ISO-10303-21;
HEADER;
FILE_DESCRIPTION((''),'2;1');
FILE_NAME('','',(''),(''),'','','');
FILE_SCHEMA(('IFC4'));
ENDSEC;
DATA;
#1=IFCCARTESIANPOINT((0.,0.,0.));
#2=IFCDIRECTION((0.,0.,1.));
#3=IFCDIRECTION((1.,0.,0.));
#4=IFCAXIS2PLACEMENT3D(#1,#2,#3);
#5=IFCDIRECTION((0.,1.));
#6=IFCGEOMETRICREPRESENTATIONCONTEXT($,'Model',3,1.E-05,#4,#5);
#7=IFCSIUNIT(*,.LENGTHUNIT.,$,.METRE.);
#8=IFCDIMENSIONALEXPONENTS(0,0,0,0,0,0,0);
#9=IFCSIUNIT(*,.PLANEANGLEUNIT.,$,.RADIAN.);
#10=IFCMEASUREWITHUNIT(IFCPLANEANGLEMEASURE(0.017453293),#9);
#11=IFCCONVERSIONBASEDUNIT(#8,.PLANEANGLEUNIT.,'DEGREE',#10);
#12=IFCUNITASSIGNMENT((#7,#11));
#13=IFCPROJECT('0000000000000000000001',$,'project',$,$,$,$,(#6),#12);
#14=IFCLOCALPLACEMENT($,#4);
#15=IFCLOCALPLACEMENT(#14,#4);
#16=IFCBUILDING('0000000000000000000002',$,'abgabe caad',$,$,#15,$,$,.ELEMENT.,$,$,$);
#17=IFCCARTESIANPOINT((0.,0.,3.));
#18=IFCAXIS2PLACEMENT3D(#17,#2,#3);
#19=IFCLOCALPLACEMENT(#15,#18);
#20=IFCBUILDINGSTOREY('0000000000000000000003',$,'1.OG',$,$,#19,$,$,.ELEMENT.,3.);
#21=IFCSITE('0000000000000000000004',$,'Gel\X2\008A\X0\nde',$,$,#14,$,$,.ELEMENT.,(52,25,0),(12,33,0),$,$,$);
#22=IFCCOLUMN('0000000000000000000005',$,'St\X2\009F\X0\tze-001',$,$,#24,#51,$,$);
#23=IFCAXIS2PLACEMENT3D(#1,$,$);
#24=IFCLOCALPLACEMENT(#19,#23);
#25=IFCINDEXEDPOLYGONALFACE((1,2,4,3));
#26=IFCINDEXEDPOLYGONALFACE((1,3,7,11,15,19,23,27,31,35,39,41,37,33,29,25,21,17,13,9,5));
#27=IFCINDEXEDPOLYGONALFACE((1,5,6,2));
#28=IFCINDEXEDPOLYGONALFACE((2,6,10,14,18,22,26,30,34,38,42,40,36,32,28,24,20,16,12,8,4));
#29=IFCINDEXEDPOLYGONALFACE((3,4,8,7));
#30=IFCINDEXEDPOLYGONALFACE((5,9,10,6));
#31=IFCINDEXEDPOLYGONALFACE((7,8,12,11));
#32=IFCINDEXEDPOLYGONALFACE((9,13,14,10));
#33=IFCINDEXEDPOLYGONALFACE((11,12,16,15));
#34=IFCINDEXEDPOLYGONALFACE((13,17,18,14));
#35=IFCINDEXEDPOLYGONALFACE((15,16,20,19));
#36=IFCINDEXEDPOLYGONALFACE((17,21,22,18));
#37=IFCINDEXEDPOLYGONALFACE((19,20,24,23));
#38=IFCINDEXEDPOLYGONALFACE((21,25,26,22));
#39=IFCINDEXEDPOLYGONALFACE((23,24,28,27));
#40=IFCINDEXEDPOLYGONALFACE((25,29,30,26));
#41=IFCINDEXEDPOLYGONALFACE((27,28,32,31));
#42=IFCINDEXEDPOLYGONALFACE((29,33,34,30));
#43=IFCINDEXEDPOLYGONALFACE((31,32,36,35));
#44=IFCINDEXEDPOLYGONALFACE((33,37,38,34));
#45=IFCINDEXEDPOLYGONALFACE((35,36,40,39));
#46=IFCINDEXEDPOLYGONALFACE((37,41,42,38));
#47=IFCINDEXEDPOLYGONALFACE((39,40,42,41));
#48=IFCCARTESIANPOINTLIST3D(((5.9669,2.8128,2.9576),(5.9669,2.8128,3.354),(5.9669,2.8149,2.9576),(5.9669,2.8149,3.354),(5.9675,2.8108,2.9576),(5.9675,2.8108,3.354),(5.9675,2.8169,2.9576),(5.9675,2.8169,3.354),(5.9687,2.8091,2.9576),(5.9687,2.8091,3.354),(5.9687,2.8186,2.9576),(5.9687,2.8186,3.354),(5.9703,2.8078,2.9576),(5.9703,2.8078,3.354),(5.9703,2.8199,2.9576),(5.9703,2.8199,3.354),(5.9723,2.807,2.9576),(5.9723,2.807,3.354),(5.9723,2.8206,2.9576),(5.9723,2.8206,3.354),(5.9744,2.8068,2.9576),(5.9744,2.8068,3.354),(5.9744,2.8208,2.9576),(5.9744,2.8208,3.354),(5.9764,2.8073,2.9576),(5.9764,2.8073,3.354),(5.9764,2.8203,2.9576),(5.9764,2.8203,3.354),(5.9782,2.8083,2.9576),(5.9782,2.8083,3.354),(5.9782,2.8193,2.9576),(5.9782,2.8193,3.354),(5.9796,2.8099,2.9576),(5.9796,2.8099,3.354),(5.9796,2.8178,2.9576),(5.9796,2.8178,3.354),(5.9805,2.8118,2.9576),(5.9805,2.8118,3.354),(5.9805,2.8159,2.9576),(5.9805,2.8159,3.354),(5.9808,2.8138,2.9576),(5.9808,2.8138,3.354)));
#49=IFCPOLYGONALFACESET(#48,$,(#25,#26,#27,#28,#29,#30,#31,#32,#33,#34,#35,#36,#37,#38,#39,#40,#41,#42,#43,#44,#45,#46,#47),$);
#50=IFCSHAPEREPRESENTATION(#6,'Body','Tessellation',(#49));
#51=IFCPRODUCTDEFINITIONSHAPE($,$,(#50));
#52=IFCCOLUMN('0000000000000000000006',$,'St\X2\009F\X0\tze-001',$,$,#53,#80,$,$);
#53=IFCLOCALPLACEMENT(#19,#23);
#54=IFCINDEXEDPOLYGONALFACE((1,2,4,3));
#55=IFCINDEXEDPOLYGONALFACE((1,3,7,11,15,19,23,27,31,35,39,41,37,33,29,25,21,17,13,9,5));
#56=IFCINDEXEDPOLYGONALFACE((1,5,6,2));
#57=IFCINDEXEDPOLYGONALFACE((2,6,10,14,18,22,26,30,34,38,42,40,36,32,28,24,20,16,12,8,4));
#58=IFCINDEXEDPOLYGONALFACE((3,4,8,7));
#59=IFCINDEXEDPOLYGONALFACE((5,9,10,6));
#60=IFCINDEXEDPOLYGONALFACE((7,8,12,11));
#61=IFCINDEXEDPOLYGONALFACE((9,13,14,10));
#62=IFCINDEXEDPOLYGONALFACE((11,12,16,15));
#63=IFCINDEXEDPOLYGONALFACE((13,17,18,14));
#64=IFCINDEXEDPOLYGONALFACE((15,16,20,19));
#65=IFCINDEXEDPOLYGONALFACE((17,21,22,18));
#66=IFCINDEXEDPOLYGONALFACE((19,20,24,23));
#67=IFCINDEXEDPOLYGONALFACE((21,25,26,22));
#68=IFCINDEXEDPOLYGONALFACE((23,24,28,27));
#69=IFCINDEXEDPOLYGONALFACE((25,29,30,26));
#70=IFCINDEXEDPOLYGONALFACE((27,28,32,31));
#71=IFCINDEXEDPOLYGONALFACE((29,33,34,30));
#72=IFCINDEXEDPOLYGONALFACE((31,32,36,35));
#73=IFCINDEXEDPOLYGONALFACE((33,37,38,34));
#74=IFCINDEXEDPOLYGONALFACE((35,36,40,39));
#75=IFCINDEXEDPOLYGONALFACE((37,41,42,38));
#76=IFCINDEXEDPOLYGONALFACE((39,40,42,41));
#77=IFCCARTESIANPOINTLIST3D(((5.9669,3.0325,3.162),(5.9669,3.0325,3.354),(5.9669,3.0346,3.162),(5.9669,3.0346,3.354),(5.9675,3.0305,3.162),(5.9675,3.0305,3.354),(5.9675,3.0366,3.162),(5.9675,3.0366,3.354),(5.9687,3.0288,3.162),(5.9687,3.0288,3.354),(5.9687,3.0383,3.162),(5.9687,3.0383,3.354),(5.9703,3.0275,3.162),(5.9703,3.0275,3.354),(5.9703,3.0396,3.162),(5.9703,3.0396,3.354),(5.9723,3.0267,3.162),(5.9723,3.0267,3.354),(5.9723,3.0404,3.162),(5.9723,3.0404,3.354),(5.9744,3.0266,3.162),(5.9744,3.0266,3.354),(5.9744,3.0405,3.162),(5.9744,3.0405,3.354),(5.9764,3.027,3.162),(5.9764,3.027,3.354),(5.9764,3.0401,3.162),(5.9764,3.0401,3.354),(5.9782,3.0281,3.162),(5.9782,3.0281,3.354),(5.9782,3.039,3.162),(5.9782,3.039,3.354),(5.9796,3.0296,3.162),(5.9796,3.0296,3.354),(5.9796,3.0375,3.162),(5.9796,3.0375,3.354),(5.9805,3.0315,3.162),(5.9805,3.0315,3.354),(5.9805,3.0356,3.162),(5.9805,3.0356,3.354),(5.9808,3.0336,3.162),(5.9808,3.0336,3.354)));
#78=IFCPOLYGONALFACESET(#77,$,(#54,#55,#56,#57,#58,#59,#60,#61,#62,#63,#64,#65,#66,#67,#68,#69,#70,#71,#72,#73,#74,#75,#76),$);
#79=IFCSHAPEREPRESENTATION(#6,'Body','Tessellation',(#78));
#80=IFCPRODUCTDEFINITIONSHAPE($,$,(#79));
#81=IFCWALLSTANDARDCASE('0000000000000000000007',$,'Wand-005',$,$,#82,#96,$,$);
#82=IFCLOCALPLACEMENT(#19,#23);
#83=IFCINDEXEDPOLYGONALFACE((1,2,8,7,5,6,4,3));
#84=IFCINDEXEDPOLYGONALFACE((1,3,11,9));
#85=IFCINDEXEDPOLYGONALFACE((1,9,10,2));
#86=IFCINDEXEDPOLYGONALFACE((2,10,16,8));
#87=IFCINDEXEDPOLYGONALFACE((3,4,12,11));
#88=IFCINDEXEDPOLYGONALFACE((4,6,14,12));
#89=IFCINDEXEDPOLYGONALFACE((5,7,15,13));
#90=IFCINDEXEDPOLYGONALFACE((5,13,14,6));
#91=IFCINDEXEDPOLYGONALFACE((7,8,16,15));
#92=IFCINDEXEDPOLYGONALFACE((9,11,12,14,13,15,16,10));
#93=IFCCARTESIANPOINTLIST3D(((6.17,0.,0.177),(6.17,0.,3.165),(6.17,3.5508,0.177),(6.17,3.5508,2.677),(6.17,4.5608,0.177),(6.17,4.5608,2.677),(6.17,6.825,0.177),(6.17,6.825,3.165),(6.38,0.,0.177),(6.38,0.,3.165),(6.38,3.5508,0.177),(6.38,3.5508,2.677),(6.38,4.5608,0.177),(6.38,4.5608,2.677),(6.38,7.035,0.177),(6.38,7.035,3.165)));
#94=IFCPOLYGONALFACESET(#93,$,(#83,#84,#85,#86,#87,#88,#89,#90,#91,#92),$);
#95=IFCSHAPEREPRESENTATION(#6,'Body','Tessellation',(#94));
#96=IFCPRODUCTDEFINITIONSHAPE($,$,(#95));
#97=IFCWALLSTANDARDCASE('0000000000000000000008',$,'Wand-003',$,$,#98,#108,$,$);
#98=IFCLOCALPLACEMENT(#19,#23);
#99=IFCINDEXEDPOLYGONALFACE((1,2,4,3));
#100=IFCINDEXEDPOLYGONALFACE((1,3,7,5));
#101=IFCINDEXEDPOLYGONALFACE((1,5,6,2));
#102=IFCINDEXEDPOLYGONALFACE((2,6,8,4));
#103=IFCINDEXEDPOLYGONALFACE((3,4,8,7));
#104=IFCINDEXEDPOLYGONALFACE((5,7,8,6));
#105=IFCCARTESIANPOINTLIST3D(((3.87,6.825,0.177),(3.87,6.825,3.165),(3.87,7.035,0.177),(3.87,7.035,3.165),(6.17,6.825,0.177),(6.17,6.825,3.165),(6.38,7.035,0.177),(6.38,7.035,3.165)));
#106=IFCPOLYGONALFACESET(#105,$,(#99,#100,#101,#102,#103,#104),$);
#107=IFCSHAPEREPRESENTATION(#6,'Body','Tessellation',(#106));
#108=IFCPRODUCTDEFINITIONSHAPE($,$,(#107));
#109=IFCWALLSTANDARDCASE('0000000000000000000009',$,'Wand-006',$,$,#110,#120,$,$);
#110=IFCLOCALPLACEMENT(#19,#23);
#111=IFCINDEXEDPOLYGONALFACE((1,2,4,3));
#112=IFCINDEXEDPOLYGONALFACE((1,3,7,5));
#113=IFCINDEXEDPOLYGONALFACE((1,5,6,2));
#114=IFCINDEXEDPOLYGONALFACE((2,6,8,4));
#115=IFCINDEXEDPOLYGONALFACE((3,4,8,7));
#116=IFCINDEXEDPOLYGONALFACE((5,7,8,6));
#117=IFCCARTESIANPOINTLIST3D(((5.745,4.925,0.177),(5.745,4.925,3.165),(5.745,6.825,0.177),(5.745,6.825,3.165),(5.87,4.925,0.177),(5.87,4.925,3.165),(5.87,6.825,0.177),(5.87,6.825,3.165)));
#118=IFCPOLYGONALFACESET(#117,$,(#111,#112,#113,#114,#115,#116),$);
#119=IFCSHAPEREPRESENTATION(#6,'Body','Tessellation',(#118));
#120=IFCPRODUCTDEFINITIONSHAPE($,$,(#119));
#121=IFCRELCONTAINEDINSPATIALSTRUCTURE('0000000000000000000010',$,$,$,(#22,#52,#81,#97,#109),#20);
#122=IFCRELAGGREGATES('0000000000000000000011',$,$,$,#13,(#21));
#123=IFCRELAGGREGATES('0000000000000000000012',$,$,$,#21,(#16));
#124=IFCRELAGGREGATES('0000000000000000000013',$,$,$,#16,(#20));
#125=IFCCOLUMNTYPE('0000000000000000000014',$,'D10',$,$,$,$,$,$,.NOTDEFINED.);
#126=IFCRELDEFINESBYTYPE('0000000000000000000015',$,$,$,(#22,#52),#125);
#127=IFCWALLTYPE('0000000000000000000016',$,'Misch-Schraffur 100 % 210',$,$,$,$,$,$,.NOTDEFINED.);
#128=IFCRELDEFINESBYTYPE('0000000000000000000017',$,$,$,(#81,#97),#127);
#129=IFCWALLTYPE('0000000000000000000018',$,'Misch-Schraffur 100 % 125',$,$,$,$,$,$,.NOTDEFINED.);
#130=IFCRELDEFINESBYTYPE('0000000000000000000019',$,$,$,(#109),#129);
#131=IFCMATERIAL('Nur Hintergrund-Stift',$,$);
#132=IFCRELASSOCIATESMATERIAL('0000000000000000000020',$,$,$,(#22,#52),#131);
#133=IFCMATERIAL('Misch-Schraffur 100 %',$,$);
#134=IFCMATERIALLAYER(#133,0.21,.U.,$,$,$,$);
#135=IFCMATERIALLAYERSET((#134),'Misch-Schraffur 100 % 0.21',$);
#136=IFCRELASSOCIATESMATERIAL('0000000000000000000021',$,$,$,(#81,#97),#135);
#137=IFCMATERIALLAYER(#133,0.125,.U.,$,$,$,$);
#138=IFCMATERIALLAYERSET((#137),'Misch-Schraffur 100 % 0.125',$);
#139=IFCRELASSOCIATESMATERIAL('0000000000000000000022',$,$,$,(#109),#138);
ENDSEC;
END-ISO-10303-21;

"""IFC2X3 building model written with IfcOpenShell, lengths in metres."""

from ifc_helpers import new_model, entity, si_unit, converted_unit, direction, frame, origin_with_axes, origin_2d_with_axis, place, context, project, spatial, polyline, rectangle, circle, outline, extrude, material, layer, layer_set, layer_usage, type_object, element, save


model = new_model("IFC2X3")

# Units and contexts
model_context = context("Model", 3, precision=1e-05, world=origin_with_axes(), true_north=direction((0.0, 1.0)))
ifc_project = project(units=[si_unit("LENGTHUNIT", "METRE"), converted_unit("PLANEANGLEUNIT", "DEGREE", entity("IfcPlaneAngleMeasure", 0.017453293), si_unit("PLANEANGLEUNIT", "RADIAN"), dimensions=[0, 0, 0, 0, 0, 0, 0])], contexts=[model_context])

# Site, building, storey
site_placement = place(None, origin_with_axes())
site = spatial("IfcSite", under=ifc_project, at=site_placement, Name="Gel\u008ande", CompositionType="ELEMENT", RefLatitude=(52, 25, 0), RefLongitude=(12, 33, 0))
building_placement = place(site_placement, origin_with_axes())
building = spatial("IfcBuilding", under=site, at=building_placement, Name="abgabe caad", CompositionType="ELEMENT")
storey_placement = place(building_placement, frame((0.0, 0.0, 3.0), z_axis=(0.0, 0.0, 1.0), x_axis=(1.0, 0.0, 0.0)))
storey = spatial("IfcBuildingStorey", under=building, at=storey_placement, Name="1.OG", CompositionType="ELEMENT", Elevation=3.0)

# Columns
ifc_material_1 = material(Name="Nur Hintergrund-Stift")
column_type = type_object("IfcColumnType", Name="D10", PredefinedType="NOTDEFINED")
column_1_placement = place(storey_placement, frame((5.9738, 2.8138, 2.9576), z_axis=(0.0, 0.0, 1.0), x_axis=(1.0, 0.0, 0.0)))
element("IfcColumn", 1, at=column_1_placement, inside=storey, type_object=column_type, material=ifc_material_1, Name="St\u009ftze-001", context=model_context, shape_type="SweptSolid", body=[
    extrude(circle(Radius=0.007, at=origin_2d_with_axis()), origin_with_axes(), (0.0, 0.0, 1.0), 0.3964),
])
column_2_placement = place(storey_placement, frame((5.9738, 3.0336, 3.162), z_axis=(0.0, 0.0, 1.0), x_axis=(1.0, 0.0, 0.0)))
element("IfcColumn", 2, at=column_2_placement, inside=storey, type_object=column_type, material=ifc_material_1, Name="St\u009ftze-001", context=model_context, shape_type="SweptSolid", body=[
    extrude(circle(Radius=0.007, at=origin_2d_with_axis()), origin_with_axes(), (0.0, 0.0, 1.0), 0.192),
])

# Wall, opening
ifc_material_2 = material(Name="Misch-Schraffur 100 %")
ifc_layer_1 = layer(ifc_material_2, 0.21, ventilated="UNKNOWN")
ifc_layer_set_1 = layer_set([ifc_layer_1], Name="Misch-Schraffur 100 % 0.21")
ifc_layer_usage_1 = layer_usage(ifc_layer_set_1, "AXIS2", "NEGATIVE", 0.0)
wall_type_1 = type_object("IfcWallType", Name="Misch-Schraffur 100 % 210", PredefinedType="NOTDEFINED")
wall_1_placement = place(storey_placement, frame((6.38, 6.825, 0.177), z_axis=(0.0, 0.0, 1.0), x_axis=(0.0, -1.0, 0.0)))
wall_1 = element("IfcWallStandardCase", 3, at=wall_1_placement, inside=storey, type_object=wall_type_1, material=ifc_layer_usage_1, Name="Wand-005", context=model_context, shape_type="SweptSolid", body=[
    extrude(outline(polyline([(0.0, -0.21), (6.825, -0.21), (6.825, 0.0), (-0.21, 0.0), (0.0, -0.21)])), origin_with_axes(), (0.0, 0.0, 1.0), 2.988),
])
opening_placement = place(wall_1_placement, frame((2.7692, 0.0, 0.0), z_axis=(0.0, 0.0, 1.0), x_axis=(1.0, 0.0, 0.0)))
element("IfcOpeningElement", 4, at=opening_placement, cuts=wall_1, context=model_context, shape_type="SweptSolid", body=[
    extrude(rectangle(XDim=1.01, YDim=2.5, at=origin_2d_with_axis()), frame((0.0, -0.211, 1.25), z_axis=(0.0, 1.0, 0.0), x_axis=(1.0, 0.0, 0.0)), (0.0, 0.0, 1.0), 0.632),
])

# Walls
ifc_layer_usage_2 = layer_usage(ifc_layer_set_1, "AXIS2", "NEGATIVE", 0.0)
wall_2_placement = place(storey_placement, frame((6.38, 6.825, 0.177), z_axis=(0.0, 0.0, 1.0), x_axis=(-1.0, 0.0, 0.0)))
element("IfcWallStandardCase", 5, at=wall_2_placement, inside=storey, type_object=wall_type_1, material=ifc_layer_usage_2, Name="Wand-003", context=model_context, shape_type="SweptSolid", body=[
    extrude(outline(polyline([(0.0, -0.21), (2.51, -0.21), (2.51, 0.0), (0.21, 0.0), (0.0, -0.21)])), origin_with_axes(), (0.0, 0.0, 1.0), 2.988),
])
ifc_layer_2 = layer(ifc_material_2, 0.125, ventilated="UNKNOWN")
ifc_layer_set_2 = layer_set([ifc_layer_2], Name="Misch-Schraffur 100 % 0.125")
ifc_layer_usage_3 = layer_usage(ifc_layer_set_2, "AXIS2", "POSITIVE", 0.0)
wall_type_2 = type_object("IfcWallType", Name="Misch-Schraffur 100 % 125", PredefinedType="NOTDEFINED")
wall_3_placement = place(storey_placement, frame((5.87, 4.925, 0.177), z_axis=(0.0, 0.0, 1.0), x_axis=(0.0, 1.0, 0.0)))
element("IfcWallStandardCase", 6, at=wall_3_placement, inside=storey, type_object=wall_type_2, material=ifc_layer_usage_3, Name="Wand-006", context=model_context, shape_type="SweptSolid", body=[
    extrude(outline(polyline([(0.0, 0.0), (1.9, 0.0), (1.9, 0.125), (0.0, 0.125), (0.0, 0.0)])), origin_with_axes(), (0.0, 0.0, 1.0), 2.988),
])

save(model, "model.ifc")
